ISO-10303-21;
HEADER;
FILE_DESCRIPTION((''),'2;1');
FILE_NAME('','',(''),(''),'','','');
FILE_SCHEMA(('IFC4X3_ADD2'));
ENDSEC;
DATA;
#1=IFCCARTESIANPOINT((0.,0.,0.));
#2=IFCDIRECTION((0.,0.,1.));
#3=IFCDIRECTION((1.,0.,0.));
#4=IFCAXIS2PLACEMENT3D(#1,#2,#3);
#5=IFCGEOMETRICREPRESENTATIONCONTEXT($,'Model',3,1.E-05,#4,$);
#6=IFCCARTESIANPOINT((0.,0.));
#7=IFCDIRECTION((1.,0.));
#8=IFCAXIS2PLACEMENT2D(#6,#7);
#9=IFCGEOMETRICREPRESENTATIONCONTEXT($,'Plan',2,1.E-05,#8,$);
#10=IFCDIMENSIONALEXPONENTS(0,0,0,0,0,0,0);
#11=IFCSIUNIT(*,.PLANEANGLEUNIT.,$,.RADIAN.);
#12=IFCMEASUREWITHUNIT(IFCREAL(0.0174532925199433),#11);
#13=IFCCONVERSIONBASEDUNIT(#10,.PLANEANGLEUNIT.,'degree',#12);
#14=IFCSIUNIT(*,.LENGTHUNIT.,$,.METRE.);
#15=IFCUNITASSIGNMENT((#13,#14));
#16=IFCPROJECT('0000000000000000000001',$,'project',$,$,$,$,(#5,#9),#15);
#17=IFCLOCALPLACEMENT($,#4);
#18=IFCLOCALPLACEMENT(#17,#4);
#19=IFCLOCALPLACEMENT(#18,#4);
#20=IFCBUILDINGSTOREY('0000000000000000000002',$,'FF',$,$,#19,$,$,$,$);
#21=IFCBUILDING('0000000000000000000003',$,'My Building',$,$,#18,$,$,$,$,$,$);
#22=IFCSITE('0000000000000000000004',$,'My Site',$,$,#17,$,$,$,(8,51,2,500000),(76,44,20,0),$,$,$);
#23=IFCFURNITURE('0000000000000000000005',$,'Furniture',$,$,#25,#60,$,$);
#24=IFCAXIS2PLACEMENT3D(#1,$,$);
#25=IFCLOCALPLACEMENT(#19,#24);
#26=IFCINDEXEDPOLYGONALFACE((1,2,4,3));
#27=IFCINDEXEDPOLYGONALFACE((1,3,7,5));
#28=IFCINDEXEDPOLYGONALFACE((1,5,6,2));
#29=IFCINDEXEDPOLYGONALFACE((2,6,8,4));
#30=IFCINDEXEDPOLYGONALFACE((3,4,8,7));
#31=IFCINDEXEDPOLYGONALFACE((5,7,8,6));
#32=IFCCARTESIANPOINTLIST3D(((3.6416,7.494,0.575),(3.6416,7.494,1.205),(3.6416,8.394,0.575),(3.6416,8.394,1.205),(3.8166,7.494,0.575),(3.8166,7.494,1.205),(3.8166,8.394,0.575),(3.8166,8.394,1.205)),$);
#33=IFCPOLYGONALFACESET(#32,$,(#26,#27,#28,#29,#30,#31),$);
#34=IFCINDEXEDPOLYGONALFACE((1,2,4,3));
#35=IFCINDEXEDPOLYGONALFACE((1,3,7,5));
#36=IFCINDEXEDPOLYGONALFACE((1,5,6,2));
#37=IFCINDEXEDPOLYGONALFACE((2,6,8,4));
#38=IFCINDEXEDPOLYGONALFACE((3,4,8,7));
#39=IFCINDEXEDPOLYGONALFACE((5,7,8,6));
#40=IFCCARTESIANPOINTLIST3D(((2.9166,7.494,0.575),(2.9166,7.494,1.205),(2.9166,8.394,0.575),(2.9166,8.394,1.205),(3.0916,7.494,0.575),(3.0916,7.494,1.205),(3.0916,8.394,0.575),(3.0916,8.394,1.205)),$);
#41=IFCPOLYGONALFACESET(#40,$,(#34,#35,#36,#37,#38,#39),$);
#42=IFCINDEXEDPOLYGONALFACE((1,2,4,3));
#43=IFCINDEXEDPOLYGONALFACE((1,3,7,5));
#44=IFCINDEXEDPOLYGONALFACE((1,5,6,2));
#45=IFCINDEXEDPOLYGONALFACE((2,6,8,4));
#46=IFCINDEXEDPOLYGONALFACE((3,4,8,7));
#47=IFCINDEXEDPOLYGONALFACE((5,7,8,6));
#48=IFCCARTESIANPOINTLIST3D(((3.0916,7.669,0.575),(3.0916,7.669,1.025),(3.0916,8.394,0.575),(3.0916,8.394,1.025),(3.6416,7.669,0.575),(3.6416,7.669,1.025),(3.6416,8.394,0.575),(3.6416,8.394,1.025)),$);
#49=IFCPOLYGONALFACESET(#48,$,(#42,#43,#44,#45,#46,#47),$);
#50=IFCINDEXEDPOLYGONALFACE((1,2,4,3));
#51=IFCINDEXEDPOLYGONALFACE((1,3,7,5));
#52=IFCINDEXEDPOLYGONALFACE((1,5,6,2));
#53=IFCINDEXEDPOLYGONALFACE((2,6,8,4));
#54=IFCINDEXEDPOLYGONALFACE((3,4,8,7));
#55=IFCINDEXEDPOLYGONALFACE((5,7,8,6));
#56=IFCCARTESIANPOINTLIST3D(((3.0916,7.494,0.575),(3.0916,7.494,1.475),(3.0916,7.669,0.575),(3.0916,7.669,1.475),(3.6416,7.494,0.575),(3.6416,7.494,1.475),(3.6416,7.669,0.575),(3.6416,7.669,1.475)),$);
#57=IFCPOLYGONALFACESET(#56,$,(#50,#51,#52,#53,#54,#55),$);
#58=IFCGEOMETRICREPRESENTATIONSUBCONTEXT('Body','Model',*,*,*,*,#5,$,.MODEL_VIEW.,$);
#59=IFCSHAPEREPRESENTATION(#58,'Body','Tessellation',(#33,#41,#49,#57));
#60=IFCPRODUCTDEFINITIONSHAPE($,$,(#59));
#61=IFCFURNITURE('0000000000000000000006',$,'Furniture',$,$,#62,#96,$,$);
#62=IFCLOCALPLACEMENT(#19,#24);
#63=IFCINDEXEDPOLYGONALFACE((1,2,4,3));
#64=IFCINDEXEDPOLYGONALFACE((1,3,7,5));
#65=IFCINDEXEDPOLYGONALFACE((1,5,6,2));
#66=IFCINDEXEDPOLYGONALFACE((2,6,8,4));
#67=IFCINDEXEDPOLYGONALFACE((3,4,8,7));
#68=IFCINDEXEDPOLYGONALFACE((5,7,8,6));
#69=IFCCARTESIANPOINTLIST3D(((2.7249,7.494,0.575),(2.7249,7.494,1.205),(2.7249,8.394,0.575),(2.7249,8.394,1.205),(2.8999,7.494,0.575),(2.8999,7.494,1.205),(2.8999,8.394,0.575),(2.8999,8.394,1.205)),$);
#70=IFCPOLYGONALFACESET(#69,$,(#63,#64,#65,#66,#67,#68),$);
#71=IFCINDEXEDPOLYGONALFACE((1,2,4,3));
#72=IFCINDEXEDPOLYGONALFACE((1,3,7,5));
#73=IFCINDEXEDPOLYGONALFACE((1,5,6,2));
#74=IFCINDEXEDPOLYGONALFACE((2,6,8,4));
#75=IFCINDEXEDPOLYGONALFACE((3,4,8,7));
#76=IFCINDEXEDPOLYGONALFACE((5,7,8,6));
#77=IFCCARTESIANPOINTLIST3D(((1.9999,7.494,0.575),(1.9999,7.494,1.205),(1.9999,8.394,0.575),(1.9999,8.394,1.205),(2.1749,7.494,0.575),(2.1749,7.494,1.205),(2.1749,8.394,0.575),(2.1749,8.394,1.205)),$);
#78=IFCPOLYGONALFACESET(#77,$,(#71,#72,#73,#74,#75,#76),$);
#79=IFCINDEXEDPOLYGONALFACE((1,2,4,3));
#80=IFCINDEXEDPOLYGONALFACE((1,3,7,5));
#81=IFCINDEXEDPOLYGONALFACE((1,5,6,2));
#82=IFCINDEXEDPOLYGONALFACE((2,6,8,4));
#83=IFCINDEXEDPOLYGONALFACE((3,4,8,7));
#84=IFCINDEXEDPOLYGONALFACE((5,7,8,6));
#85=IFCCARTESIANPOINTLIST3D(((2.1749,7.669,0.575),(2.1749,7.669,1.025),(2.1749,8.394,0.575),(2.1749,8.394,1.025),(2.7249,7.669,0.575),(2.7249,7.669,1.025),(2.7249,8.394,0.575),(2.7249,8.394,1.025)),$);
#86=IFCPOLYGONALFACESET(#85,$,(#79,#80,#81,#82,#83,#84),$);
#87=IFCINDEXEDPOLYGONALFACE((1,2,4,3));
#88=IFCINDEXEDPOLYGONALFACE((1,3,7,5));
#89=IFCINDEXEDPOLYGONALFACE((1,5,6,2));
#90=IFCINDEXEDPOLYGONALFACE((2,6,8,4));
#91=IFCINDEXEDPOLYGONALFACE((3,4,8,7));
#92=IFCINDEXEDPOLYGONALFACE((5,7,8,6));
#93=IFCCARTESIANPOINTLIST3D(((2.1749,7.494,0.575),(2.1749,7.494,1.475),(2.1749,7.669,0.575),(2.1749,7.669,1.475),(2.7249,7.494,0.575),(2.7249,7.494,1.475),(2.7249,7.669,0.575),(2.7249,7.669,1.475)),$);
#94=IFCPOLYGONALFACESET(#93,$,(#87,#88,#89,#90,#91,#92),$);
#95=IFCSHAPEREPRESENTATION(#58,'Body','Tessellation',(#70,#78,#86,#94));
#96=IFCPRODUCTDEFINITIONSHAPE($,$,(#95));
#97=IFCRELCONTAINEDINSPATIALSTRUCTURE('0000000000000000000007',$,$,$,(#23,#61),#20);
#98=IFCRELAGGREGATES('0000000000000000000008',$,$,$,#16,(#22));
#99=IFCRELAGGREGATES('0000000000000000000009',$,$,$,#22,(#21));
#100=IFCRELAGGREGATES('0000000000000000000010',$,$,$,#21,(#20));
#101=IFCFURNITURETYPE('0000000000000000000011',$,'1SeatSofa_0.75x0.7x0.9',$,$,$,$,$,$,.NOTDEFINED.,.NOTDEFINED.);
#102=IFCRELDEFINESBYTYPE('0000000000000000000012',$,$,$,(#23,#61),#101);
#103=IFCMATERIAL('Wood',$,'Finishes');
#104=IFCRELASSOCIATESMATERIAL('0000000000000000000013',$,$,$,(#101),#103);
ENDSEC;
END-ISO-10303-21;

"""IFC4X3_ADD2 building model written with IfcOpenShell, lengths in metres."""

from ifc_helpers import new_model, entity, si_unit, converted_unit, frame, origin_with_axes, origin_2d_with_axis, place, context, subcontext, project, spatial, line, indexed_curve, outline, extrude, shape, source, transform, mapped, material, type_object, type_shapes, element, save


model = new_model("IFC4X3_ADD2")

# Units and contexts
model_context = context("Model", 3, precision=1e-05, world=origin_with_axes())
plan_context = context("Plan", 2, precision=1e-05, world=origin_2d_with_axis())
body_context_1 = subcontext(model_context, "Body", "Model", "MODEL_VIEW")
body_context_2 = subcontext(plan_context, "Body", "Plan", "PLAN_VIEW")
ifc_project = project(units=[converted_unit("PLANEANGLEUNIT", "degree", entity("IfcReal", 0.0174532925199433), si_unit("PLANEANGLEUNIT", "RADIAN"), dimensions=[0, 0, 0, 0, 0, 0, 0]), si_unit("LENGTHUNIT", "METRE")], contexts=[model_context, plan_context])

# Site, building, storey
site_placement = place(None, origin_with_axes())
site = spatial("IfcSite", under=ifc_project, at=site_placement, Name="My Site", RefLatitude=(8, 51, 2, 500000), RefLongitude=(76, 44, 20, 0))
building_placement = place(site_placement, origin_with_axes())
building = spatial("IfcBuilding", under=site, at=building_placement, Name="My Building")
storey_placement = place(building_placement, origin_with_axes())
storey = spatial("IfcBuildingStorey", under=building, at=storey_placement, Name="FF")

# Shared definitions
ifc_material_1 = material(Name="Wood", Category="Finishes")

# Furniture
furniture_type = type_object("IfcFurnitureType", Name="1SeatSofa_0.75x0.7x0.9", AssemblyPlace="NOTDEFINED", PredefinedType="NOTDEFINED", material=ifc_material_1)
shared_shape_1 = source(origin_with_axes(), body_context_1, "Body", "SweptSolid", [
    extrude(outline(indexed_curve([(0.0, 0.0), (0.175, 0.0), (0.175, 0.9), (0.0, 0.9)], segments=[line(1, 2, 3, 4, 1)])), frame((-0.45, -0.9, 0.0), z_axis=(0.0, 0.0, 1.0), x_axis=(1.0, 0.0, 0.0)), (0.0, 0.0, 1.0), 0.63),
    extrude(outline(indexed_curve([(0.0, 0.0), (0.175, 0.0), (0.175, 0.9), (0.0, 0.9)], segments=[line(1, 2, 3, 4, 1)])), frame((0.275, -0.9, 0.0), z_axis=(0.0, 0.0, 1.0), x_axis=(1.0, 0.0, 0.0)), (0.0, 0.0, 1.0), 0.63),
    extrude(outline(indexed_curve([(0.175, 0.0), (0.725, 0.0), (0.725, 0.725), (0.175, 0.725)], segments=[line(1, 2, 3, 4, 1)])), frame((-0.45, -0.9, 0.0), z_axis=(0.0, 0.0, 1.0), x_axis=(1.0, 0.0, 0.0)), (0.0, 0.0, 1.0), 0.45),
    extrude(outline(indexed_curve([(0.175, 0.9), (0.175, 0.725), (0.725, 0.725), (0.725, 0.9), (0.175, 0.9)])), frame((-0.45, -0.9, 0.0), z_axis=(0.0, 0.0, 1.0), x_axis=(1.0, 0.0, 0.0)), (0.0, 0.0, 1.0), 0.9),
])
shared_shape_2 = source(origin_with_axes(), body_context_2, "Body", "Annotation2D", [
    entity("IfcGeometricCurveSet", [entity("IfcIndexedPolyCurve", entity("IfcCartesianPointList2D", [[0.275, -0.175], [0.275, -0.9], [0.45, -0.9], [0.45, 0.0], [0.275, 0.0], [0.275, -0.9], [-0.275, -0.9], [-0.275, 0.0], [-0.275, -0.175], [0.275, -0.175], [0.275, 0.0], [-0.275, 0.0], [-0.45, 0.0], [-0.45, -0.9], [-0.275, -0.9], [-0.275, -0.175]]))]),
])
type_shapes(furniture_type, [shared_shape_1, shared_shape_2])
for number, where, z_axis, x_axis, name in (
    (1, (3.3666, 7.494, 0.575), (0.0, 0.0, 1.0), (-1.0, 0.000003, 0.0), "Furniture"),
    (2, (2.4499, 7.494, 0.575), (0.0, 0.0, 1.0), (-1.0, 0.000003, 0.0), "Furniture"),
):
    element("IfcFurniture", number, at=place(storey_placement, frame(where, z_axis=z_axis, x_axis=x_axis)), inside=storey, type_object=furniture_type, Name=name, shapes=[
        shape(body_context_1, "Body", "MappedRepresentation", [mapped(shared_shape_1, transform((0.0, 0.0, 0.0), x_axis=(1.0, 0.0, 0.0), y_axis=(0.0, 1.0, 0.0), z_axis=(0.0, 0.0, 1.0), scale=1.0))]),
        shape(body_context_2, "Body", "MappedRepresentation", [mapped(shared_shape_2, transform((0.0, 0.0, 0.0), x_axis=(1.0, 0.0, 0.0), y_axis=(0.0, 1.0, 0.0), z_axis=(0.0, 0.0, 1.0), scale=1.0))]),
    ])

save(model, "model.ifc")
